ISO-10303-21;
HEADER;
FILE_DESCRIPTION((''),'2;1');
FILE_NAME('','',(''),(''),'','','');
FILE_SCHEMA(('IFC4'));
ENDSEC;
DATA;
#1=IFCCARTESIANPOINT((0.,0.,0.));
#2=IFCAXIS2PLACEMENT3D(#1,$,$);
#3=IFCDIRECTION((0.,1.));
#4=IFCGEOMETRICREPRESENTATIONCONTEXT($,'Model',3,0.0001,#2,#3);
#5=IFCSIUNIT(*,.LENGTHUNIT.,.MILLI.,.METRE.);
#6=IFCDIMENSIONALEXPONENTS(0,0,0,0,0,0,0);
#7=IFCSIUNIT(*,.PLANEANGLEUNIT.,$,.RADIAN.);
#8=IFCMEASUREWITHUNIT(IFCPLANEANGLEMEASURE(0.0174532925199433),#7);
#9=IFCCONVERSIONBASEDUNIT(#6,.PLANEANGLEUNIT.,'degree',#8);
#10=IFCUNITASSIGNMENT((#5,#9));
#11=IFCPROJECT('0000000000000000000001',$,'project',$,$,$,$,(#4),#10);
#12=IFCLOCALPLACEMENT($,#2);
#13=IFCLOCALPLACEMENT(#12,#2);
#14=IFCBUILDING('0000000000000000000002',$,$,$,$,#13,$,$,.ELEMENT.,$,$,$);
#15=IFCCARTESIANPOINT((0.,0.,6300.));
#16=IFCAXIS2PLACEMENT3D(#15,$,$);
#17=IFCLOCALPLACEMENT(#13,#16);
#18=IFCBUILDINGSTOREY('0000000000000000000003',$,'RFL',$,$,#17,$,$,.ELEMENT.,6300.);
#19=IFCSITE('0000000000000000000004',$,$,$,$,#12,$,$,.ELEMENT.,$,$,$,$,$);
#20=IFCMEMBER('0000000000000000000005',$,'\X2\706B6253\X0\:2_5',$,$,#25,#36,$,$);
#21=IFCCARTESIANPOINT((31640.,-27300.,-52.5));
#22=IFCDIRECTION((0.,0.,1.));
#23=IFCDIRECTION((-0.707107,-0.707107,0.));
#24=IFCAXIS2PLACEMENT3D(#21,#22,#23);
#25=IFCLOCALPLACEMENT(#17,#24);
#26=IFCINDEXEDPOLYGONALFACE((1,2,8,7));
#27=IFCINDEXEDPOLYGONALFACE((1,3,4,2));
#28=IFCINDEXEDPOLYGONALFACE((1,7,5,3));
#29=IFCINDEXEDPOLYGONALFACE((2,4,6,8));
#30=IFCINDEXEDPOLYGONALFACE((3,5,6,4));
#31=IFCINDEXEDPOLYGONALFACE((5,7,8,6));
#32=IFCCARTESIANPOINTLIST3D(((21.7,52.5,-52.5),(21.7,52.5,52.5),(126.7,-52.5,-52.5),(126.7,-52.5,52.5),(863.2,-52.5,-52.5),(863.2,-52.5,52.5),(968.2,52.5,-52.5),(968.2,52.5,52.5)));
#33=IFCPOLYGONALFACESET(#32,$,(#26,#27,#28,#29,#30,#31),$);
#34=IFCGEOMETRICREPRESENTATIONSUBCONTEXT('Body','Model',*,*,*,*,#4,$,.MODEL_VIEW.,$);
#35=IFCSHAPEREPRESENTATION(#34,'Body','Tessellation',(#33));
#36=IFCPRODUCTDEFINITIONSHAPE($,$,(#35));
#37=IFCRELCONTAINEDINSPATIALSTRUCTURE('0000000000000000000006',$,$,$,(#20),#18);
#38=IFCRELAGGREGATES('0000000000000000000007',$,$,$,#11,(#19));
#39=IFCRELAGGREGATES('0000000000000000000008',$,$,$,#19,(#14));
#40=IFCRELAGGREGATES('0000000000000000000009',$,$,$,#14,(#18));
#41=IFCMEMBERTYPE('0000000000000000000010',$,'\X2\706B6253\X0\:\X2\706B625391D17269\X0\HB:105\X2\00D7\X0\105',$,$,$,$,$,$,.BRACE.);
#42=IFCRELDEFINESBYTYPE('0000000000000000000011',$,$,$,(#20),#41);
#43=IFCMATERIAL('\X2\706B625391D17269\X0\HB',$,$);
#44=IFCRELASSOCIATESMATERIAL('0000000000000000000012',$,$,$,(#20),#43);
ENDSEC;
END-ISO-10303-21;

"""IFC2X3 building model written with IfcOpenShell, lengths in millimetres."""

from ifc_helpers import new_model, entity, si_unit, converted_unit, direction, frame, origin, place, context, subcontext, project, spatial, polyline, outline, extrude, material, type_object, element, save


model = new_model("IFC2X3")

# Units and contexts
model_context = context("Model", 3, precision=0.0001, world=origin(), true_north=direction((0.0, 1.0)))
body_context = subcontext(model_context, "Body", "Model", "MODEL_VIEW")
ifc_project = project(units=[si_unit("LENGTHUNIT", "METRE", prefix="MILLI"), converted_unit("PLANEANGLEUNIT", "degree", entity("IfcPlaneAngleMeasure", 0.0174532925199433), si_unit("PLANEANGLEUNIT", "RADIAN"), dimensions=[0, 0, 0, 0, 0, 0, 0])], contexts=[model_context])

# Site, building, storey
site_placement = place(None, origin())
site = spatial("IfcSite", under=ifc_project, at=site_placement, CompositionType="ELEMENT")
building_placement = place(site_placement, origin())
building = spatial("IfcBuilding", under=site, at=building_placement, CompositionType="ELEMENT")
storey_placement = place(building_placement, frame((0.0, 0.0, 6300.0)))
storey = spatial("IfcBuildingStorey", under=building, at=storey_placement, Name="RFL", CompositionType="ELEMENT", Elevation=6300.0)

# Member
ifc_material = material(Name="火打金物HB")
member_type = type_object("IfcMemberType", Name="火打:火打金物HB:105×105", PredefinedType="BRACE")
member_1_placement = place(storey_placement, frame((31640.0, -27300.0, -52.5), z_axis=(0.0, 0.0, 1.0), x_axis=(-0.707107, -0.707107, 0.0)))
element("IfcMember", 1, at=member_1_placement, inside=storey, type_object=member_type, material=ifc_material, Name="火打:2_5", context=body_context, shape_type="SweptSolid", body=[
    extrude(outline(polyline([(126.7, -52.5, 0.0), (21.7, 52.5, 0.0), (968.2, 52.5, 0.0), (863.2, -52.5, 0.0), (126.7, -52.5, 0.0)])), frame((0.0, 0.0, -52.5), z_axis=(0.0, 0.0, 1.0), x_axis=(1.0, 0.0, 0.0)), (0.0, 0.0, 1.0), 105.0),
])

save(model, "model.ifc")
